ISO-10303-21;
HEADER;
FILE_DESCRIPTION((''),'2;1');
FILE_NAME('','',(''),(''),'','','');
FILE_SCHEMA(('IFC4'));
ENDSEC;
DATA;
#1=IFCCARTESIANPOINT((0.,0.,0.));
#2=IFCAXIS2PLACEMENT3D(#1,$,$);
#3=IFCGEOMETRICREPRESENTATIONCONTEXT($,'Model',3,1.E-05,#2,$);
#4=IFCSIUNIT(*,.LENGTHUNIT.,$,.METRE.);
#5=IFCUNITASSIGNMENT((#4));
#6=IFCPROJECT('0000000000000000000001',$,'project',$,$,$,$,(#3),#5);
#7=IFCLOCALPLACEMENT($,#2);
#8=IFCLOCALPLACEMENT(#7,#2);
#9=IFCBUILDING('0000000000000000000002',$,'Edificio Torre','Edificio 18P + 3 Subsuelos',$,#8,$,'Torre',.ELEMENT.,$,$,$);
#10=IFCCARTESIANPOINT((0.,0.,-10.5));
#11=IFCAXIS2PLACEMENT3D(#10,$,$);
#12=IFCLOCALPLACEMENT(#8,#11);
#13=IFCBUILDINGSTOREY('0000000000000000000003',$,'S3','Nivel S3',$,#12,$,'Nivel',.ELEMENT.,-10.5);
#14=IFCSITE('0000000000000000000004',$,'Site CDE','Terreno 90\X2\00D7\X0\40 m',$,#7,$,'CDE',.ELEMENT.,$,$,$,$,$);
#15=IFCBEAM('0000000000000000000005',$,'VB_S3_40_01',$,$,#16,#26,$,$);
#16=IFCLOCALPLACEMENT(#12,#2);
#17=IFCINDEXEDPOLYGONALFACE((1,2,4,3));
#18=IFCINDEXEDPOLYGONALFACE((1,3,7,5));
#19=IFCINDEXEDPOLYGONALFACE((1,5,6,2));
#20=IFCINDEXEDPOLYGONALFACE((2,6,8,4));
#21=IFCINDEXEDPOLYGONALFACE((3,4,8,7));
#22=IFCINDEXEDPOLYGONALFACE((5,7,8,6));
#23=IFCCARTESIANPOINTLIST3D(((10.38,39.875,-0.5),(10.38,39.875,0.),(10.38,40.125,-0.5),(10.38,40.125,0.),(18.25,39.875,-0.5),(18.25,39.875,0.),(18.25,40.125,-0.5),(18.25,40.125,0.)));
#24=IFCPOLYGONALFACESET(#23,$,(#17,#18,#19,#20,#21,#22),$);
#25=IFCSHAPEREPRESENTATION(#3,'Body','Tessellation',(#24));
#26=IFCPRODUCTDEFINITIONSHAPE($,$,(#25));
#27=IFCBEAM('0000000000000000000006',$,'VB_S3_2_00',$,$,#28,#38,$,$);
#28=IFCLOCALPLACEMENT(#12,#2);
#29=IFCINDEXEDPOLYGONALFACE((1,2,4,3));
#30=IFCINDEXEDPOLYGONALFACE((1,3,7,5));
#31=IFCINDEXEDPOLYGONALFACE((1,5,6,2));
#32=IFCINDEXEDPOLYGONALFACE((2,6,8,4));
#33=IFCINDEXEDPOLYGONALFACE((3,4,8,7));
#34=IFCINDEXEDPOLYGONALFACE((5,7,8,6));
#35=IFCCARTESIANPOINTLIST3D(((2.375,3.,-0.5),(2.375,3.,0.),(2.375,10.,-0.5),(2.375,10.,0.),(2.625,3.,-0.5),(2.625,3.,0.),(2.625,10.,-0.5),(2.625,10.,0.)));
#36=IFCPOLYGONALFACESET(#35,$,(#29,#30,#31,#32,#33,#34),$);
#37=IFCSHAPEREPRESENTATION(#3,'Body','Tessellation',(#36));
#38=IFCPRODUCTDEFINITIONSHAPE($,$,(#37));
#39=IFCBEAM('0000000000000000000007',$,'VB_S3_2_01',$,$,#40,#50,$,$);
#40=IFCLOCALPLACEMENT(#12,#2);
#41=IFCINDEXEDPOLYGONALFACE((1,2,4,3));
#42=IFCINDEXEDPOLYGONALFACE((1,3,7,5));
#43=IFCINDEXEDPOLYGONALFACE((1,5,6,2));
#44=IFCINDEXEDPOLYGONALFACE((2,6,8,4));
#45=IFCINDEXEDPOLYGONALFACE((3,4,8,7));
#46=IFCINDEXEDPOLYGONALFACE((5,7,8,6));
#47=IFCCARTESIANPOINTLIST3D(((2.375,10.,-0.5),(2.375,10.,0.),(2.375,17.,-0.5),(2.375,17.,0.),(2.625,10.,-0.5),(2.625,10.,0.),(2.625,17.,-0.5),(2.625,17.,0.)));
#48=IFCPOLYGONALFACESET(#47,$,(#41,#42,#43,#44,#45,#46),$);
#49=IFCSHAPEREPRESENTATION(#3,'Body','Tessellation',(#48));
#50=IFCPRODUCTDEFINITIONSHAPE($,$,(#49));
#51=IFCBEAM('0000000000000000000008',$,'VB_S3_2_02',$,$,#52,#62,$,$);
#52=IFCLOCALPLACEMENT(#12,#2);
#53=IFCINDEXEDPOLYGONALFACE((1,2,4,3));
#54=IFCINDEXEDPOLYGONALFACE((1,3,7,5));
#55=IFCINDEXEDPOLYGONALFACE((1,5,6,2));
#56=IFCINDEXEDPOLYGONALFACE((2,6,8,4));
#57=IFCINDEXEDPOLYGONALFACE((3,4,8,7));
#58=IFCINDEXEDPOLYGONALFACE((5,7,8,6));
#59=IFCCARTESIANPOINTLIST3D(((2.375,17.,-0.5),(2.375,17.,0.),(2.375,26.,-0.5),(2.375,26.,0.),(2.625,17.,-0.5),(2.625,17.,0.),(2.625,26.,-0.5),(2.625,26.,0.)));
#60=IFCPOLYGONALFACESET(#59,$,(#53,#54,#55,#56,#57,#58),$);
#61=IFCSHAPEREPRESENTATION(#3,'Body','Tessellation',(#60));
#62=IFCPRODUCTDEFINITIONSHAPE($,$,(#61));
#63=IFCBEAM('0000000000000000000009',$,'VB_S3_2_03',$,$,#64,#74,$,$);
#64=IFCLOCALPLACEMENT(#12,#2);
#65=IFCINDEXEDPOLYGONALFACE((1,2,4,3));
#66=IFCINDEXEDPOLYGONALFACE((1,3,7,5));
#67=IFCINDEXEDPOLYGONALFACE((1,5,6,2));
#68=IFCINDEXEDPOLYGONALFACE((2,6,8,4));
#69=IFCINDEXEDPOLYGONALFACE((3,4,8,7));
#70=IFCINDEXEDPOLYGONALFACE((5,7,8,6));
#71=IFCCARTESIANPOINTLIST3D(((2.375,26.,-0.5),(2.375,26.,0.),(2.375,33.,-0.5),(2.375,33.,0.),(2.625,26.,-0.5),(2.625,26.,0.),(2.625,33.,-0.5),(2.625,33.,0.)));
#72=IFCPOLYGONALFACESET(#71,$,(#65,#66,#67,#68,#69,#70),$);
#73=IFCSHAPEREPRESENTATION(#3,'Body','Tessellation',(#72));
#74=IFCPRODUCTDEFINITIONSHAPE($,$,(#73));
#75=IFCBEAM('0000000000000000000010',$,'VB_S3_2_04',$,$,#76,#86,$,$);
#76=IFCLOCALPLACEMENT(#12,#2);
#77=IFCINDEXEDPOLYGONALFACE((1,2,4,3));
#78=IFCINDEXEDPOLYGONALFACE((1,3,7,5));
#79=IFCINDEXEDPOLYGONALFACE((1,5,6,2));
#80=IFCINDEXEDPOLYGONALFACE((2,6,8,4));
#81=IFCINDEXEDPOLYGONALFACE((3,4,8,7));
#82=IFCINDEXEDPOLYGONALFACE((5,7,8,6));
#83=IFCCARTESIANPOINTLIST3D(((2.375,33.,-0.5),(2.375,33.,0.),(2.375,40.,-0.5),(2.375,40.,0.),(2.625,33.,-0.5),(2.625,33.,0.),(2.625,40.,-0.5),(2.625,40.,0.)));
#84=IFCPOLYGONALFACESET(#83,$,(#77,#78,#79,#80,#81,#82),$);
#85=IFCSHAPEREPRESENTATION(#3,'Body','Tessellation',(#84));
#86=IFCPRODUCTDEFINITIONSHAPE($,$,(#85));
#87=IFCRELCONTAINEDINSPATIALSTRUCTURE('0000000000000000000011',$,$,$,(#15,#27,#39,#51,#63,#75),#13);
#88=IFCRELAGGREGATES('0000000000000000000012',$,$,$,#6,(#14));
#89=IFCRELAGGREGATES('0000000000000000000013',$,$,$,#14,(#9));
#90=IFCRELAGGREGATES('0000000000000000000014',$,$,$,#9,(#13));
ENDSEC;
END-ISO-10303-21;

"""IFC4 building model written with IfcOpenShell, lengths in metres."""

from ifc_helpers import new_model, si_unit, frame, origin, origin_2d, place, context, project, spatial, rectangle, extrude, element, save


model = new_model("IFC4")

# Units and contexts
model_context = context("Model", 3, precision=1e-05, world=origin())
ifc_project = project(units=[si_unit("LENGTHUNIT", "METRE")], contexts=[model_context])

# Site, building, storey
site_placement = place(None, origin())
site = spatial("IfcSite", under=ifc_project, at=site_placement, Name="Site CDE", Description="Terreno 90×40 m", LongName="CDE", CompositionType="ELEMENT")
building_placement = place(site_placement, origin())
building = spatial("IfcBuilding", under=site, at=building_placement, Name="Edificio Torre", Description="Edificio 18P + 3 Subsuelos", LongName="Torre", CompositionType="ELEMENT")
storey_placement = place(building_placement, frame((0.0, 0.0, -10.5)))
storey = spatial("IfcBuildingStorey", under=building, at=storey_placement, Name="S3", Description="Nivel S3", LongName="Nivel", CompositionType="ELEMENT", Elevation=-10.5)

# Beams
beam_1_placement = place(storey_placement, frame((14.315, 40.0, -0.5)))
element("IfcBeam", 1, at=beam_1_placement, inside=storey, Name="VB_S3_40_01", context=model_context, shape_type="SweptSolid", body=[
    extrude(rectangle(XDim=7.87, YDim=0.25, at=origin_2d()), origin(), (0.0, 0.0, 1.0), 0.5),
])
for number, where, name in (
    (2, (2.5, 6.5, -0.5), "VB_S3_2_00"),
    (3, (2.5, 13.5, -0.5), "VB_S3_2_01"),
):
    element("IfcBeam", number, at=place(storey_placement, frame(where)), inside=storey, Name=name, context=model_context, shape_type="SweptSolid", body=[
        extrude(rectangle(XDim=0.25, YDim=7.0, at=origin_2d()), origin(), (0.0, 0.0, 1.0), 0.5),
    ])
beam_2_placement = place(storey_placement, frame((2.5, 21.5, -0.5)))
element("IfcBeam", 4, at=beam_2_placement, inside=storey, Name="VB_S3_2_02", context=model_context, shape_type="SweptSolid", body=[
    extrude(rectangle(XDim=0.25, YDim=9.0, at=origin_2d()), origin(), (0.0, 0.0, 1.0), 0.5),
])
for number, where, name in (
    (5, (2.5, 29.5, -0.5), "VB_S3_2_03"),
    (6, (2.5, 36.5, -0.5), "VB_S3_2_04"),
):
    element("IfcBeam", number, at=place(storey_placement, frame(where)), inside=storey, Name=name, context=model_context, shape_type="SweptSolid", body=[
        extrude(rectangle(XDim=0.25, YDim=7.0, at=origin_2d()), origin(), (0.0, 0.0, 1.0), 0.5),
    ])

save(model, "model.ifc")
